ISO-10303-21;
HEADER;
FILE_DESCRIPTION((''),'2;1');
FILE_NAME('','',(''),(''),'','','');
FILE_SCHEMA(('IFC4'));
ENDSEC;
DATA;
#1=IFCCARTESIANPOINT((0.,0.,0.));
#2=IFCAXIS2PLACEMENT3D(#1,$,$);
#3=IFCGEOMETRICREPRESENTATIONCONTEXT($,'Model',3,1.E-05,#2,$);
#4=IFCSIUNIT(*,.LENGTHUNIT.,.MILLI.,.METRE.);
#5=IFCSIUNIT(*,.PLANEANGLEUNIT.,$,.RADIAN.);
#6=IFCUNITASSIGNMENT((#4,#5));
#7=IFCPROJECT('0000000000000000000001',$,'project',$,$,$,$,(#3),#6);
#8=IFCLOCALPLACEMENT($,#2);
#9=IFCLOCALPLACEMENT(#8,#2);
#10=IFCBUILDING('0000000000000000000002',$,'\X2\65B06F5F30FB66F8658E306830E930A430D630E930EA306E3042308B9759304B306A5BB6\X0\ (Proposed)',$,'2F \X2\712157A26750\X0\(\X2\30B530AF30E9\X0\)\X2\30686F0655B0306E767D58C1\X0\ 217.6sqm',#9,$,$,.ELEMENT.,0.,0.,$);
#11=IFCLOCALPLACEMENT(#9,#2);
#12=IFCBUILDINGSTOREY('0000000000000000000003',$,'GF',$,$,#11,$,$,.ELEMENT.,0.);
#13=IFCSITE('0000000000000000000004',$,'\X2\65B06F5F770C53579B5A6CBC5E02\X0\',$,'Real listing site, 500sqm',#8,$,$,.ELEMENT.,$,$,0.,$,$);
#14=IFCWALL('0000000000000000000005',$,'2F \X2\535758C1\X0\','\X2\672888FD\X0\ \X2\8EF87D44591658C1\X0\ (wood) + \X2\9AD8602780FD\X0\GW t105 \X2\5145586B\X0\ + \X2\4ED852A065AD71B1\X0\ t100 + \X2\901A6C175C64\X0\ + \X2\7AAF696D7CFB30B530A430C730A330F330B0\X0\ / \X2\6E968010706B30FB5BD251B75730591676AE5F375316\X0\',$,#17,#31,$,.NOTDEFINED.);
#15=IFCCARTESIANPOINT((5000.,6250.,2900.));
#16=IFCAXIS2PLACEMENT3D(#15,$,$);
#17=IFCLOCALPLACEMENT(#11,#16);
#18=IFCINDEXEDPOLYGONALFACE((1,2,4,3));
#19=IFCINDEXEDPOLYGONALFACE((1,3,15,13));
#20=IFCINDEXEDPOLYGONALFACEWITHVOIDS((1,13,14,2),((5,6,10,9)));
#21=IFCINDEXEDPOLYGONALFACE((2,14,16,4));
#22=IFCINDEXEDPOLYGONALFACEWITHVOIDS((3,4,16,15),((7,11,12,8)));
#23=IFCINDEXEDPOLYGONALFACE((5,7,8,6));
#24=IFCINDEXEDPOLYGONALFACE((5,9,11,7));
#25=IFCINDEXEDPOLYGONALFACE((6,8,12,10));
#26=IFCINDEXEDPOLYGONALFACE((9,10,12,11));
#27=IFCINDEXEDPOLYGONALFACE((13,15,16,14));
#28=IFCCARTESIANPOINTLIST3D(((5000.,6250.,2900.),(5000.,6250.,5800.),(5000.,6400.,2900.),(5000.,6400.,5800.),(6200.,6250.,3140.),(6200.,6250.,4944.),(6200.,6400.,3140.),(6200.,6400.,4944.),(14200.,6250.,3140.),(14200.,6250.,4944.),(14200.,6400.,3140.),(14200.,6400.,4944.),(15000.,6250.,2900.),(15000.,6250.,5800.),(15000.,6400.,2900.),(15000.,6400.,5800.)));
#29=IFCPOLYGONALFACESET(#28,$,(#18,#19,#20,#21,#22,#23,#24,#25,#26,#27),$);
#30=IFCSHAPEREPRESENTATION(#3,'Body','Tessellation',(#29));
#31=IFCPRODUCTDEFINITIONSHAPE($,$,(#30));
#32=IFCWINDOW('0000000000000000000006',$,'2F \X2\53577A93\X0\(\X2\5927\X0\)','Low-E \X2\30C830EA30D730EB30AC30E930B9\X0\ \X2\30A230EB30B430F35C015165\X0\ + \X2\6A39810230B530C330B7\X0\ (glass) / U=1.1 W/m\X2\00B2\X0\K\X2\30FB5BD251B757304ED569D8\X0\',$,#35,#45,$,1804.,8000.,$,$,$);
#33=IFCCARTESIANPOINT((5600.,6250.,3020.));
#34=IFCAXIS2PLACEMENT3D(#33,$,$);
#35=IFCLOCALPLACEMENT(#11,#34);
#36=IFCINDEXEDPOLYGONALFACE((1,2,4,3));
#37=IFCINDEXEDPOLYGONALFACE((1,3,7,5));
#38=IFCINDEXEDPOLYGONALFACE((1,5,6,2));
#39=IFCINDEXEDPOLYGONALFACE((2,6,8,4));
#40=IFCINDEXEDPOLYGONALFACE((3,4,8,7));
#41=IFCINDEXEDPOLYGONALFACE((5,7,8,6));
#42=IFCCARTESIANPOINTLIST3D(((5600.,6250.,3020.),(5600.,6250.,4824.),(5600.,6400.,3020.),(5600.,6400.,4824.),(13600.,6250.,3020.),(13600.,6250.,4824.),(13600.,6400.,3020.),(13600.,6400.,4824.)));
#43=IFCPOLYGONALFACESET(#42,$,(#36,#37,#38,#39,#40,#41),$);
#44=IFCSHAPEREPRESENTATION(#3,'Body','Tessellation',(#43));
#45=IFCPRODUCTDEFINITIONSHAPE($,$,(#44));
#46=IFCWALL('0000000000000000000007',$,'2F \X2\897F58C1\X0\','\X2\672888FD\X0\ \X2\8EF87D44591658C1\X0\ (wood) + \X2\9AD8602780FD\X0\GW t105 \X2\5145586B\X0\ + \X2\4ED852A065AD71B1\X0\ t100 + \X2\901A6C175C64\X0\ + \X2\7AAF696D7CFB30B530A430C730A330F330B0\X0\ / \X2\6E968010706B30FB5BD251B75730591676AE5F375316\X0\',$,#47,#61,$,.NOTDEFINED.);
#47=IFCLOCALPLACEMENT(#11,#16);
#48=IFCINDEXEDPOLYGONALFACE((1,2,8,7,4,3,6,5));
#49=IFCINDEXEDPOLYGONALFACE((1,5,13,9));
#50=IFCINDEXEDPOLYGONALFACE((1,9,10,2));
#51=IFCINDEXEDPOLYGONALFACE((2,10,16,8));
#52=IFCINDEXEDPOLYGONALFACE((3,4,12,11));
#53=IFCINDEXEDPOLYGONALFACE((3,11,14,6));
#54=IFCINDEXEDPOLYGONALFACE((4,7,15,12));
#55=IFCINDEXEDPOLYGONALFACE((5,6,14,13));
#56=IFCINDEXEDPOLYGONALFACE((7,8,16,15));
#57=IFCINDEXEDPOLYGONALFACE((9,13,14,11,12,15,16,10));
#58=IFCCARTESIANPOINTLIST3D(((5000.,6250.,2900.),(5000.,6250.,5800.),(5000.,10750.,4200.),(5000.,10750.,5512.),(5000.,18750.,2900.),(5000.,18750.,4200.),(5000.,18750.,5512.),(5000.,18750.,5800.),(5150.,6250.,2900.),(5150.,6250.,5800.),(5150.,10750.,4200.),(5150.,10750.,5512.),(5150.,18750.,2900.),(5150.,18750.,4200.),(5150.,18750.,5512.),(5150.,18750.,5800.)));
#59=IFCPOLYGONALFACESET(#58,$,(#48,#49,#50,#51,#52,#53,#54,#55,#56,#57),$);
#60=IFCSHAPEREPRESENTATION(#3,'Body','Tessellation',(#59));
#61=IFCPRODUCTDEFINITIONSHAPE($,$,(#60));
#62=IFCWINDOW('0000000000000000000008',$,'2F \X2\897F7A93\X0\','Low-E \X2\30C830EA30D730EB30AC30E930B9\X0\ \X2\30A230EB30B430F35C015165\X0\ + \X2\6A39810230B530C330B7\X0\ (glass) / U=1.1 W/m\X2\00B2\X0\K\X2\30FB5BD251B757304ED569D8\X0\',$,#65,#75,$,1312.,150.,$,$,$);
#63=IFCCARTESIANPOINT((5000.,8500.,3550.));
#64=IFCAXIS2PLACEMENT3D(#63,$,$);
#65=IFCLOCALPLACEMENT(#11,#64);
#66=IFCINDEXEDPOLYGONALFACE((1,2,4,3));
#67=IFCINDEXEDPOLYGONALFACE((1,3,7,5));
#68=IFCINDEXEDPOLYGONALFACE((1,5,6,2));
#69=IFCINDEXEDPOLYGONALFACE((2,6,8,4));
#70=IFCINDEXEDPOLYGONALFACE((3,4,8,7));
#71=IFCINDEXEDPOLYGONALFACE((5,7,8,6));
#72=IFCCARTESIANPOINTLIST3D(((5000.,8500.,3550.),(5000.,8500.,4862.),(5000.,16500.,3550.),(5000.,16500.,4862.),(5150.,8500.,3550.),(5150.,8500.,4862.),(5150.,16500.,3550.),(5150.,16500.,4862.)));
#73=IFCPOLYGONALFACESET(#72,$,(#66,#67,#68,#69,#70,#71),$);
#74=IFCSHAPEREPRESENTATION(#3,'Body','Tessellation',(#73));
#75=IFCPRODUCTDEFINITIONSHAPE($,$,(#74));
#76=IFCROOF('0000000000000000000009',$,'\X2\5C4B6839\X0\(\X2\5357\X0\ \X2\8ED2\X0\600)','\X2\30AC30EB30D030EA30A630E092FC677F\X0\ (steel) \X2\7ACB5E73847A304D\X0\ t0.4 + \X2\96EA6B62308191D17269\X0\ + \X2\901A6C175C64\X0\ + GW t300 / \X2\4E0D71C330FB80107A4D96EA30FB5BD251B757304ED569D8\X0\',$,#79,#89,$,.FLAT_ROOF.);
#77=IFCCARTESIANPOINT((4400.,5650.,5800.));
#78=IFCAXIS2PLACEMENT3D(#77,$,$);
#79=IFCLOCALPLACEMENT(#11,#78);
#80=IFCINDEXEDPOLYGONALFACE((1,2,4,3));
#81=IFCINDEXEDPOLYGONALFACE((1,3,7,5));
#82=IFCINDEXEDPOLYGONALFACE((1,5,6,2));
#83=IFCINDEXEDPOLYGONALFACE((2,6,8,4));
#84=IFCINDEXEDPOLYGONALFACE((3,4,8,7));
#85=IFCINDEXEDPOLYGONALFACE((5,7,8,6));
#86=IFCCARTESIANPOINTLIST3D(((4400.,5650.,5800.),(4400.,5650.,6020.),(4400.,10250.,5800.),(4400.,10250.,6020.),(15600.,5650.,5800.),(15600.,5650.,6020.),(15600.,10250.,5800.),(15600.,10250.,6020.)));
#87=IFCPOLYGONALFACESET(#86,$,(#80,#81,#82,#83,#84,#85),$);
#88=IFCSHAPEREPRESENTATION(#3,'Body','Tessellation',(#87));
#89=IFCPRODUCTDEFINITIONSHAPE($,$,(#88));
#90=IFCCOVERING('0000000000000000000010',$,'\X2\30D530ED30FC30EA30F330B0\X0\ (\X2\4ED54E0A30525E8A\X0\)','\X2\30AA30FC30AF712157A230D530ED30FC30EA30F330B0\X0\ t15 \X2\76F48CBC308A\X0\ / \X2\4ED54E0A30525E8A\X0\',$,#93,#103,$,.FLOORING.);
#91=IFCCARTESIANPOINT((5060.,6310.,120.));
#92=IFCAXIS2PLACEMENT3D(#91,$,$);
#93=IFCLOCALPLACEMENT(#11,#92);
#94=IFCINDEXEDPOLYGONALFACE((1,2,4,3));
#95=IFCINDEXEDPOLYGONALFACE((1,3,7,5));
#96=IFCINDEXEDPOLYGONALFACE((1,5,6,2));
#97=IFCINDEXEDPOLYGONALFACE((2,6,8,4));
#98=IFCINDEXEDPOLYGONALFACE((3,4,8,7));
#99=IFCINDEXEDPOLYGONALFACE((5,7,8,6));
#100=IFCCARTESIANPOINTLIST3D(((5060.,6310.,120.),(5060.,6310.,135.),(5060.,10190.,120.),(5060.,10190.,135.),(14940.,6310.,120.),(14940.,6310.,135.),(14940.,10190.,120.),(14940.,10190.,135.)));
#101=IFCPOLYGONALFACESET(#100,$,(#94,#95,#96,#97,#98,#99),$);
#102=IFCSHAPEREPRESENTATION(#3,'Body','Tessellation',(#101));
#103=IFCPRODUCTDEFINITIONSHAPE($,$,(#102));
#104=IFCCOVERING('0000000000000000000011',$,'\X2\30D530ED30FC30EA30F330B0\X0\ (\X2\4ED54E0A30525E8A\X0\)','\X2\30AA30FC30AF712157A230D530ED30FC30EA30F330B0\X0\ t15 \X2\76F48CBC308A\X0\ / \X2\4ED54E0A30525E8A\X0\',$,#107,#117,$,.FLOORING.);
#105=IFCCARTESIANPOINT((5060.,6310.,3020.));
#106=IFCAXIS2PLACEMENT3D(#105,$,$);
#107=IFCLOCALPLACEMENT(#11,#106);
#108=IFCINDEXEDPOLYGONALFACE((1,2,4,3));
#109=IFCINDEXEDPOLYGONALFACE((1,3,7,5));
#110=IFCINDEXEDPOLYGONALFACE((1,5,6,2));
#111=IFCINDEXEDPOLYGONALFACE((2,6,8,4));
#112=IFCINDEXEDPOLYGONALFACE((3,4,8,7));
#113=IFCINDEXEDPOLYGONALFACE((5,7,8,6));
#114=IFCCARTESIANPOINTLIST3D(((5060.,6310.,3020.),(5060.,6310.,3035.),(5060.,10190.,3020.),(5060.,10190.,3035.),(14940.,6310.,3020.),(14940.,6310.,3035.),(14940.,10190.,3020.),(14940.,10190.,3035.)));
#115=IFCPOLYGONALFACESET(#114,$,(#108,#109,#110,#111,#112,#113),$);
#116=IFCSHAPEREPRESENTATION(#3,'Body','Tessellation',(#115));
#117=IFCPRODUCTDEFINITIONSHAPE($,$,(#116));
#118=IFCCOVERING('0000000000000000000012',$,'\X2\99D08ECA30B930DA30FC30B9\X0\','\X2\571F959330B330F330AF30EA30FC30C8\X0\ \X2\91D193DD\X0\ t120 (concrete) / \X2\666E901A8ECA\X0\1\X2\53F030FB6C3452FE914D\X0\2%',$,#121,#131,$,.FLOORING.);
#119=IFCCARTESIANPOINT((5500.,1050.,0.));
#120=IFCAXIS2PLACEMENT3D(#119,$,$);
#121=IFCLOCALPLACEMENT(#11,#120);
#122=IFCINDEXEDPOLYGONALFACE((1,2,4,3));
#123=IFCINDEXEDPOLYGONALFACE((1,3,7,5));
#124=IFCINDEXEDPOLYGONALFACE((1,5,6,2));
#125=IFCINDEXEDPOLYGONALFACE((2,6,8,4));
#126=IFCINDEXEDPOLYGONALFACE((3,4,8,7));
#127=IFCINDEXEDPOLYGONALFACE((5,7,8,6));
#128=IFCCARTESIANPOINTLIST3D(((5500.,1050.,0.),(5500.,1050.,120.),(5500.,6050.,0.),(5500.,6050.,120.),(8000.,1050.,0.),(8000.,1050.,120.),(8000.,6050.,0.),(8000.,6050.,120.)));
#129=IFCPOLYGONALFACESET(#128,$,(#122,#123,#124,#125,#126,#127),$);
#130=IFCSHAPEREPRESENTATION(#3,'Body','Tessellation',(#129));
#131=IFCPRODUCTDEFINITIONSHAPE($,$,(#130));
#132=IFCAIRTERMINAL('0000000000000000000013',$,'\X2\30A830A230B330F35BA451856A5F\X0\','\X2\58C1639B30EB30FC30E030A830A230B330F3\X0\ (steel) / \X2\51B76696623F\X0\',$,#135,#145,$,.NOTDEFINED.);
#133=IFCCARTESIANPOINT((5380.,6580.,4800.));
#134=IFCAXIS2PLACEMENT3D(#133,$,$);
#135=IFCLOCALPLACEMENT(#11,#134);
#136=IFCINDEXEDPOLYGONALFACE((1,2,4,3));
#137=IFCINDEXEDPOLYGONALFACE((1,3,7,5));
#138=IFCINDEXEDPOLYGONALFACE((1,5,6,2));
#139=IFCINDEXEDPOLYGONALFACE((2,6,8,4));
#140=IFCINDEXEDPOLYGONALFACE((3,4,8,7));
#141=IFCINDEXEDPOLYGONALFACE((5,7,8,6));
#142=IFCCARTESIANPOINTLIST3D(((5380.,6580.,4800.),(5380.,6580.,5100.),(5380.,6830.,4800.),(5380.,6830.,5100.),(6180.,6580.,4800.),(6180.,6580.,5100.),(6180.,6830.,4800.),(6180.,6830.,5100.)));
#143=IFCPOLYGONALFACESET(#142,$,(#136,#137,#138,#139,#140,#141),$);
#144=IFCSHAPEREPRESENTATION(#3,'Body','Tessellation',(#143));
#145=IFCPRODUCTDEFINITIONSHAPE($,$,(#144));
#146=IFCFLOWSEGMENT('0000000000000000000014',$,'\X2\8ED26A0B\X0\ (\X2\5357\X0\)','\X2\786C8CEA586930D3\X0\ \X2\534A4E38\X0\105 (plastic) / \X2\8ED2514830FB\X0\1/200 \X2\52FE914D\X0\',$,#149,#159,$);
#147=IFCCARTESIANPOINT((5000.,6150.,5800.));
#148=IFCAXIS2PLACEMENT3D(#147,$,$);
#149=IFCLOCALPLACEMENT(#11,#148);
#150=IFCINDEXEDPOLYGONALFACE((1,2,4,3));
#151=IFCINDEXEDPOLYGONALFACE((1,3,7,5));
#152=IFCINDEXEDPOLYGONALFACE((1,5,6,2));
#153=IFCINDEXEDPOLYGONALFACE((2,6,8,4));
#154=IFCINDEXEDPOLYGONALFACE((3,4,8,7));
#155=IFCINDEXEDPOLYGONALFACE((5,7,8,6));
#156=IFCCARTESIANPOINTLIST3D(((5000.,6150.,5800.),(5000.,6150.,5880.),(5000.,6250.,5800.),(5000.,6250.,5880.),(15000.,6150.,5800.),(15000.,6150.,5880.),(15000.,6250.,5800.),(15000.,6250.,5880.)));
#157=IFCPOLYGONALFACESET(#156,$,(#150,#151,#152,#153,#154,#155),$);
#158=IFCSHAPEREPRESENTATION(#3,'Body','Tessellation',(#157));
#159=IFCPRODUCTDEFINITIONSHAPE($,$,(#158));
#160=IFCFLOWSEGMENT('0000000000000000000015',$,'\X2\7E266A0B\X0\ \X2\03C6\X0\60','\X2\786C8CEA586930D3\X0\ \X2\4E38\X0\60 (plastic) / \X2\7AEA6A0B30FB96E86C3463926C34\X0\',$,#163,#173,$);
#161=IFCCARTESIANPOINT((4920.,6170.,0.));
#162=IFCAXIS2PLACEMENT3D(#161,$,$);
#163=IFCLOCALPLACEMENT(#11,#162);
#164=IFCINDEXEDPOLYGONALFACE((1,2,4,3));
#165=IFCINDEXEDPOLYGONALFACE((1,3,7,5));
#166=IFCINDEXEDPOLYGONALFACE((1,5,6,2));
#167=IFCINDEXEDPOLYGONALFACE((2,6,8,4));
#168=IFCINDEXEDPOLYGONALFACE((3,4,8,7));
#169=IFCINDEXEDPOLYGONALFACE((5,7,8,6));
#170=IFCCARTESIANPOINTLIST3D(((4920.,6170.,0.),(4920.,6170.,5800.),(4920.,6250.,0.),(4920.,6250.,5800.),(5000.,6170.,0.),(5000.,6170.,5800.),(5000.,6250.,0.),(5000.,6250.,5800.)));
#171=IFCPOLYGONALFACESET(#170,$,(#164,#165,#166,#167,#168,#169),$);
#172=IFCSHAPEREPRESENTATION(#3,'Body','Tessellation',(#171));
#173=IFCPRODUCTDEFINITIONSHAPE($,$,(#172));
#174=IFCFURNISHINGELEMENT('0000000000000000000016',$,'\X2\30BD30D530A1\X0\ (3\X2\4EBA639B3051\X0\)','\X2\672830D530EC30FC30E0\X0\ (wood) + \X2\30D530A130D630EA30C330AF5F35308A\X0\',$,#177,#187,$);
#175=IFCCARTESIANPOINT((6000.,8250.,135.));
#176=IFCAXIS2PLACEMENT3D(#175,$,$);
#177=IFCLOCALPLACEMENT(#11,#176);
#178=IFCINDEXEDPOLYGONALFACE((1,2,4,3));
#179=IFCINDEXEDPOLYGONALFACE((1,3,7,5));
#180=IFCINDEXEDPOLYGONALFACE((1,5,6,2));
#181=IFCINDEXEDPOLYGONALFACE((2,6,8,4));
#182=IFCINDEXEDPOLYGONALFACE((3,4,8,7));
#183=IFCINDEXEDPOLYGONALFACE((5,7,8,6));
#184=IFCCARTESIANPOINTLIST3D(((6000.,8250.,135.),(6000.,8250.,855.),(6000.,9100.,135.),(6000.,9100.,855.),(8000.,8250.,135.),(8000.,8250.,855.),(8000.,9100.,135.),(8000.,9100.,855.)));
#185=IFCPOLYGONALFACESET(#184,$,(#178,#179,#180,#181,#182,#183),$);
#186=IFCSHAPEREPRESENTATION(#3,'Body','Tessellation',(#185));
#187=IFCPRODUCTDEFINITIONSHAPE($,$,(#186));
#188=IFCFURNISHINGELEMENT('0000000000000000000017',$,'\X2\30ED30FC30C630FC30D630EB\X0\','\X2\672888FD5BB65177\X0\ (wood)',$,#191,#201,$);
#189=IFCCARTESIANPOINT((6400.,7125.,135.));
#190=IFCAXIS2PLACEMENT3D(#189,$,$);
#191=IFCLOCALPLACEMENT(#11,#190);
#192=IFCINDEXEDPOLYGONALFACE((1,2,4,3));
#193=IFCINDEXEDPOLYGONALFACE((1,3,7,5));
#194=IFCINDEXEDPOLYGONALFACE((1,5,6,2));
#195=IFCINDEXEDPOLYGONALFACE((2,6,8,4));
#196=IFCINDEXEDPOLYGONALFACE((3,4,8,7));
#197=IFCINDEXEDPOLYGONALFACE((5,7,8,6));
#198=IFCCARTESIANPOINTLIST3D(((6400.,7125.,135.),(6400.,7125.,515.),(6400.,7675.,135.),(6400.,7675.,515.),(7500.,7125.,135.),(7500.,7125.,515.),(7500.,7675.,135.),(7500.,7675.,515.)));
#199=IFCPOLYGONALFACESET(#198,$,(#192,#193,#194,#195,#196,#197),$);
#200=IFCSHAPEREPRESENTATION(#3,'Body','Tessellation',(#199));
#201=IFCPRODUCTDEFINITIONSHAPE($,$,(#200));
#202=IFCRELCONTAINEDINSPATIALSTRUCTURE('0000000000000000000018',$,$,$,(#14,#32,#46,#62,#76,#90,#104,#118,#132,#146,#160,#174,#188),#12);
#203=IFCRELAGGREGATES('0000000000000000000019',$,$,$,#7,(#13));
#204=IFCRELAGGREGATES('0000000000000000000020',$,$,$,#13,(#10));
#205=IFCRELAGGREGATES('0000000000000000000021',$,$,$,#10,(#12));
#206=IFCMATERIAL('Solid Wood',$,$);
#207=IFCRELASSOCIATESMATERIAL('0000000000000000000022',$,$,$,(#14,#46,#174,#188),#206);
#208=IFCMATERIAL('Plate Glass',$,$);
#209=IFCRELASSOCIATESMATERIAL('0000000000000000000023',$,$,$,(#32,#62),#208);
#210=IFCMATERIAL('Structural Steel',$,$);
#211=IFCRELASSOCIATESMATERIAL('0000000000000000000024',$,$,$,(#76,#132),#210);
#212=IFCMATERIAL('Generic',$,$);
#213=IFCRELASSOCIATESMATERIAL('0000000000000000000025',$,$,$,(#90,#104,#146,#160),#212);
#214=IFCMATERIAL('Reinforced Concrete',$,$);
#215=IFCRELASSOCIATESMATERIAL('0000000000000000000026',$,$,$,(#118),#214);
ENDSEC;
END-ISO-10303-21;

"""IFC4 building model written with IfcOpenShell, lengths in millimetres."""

from ifc_helpers import new_model, si_unit, frame, frame_2d, origin, place, context, project, spatial, rectangle, extrude, material, element, fill, save


model = new_model("IFC4")

# Units and contexts
model_context = context("Model", 3, precision=1e-05, world=origin())
ifc_project = project(units=[si_unit("LENGTHUNIT", "METRE", prefix="MILLI"), si_unit("PLANEANGLEUNIT", "RADIAN")], contexts=[model_context])

# Site, building, storey
site_placement = place(None, origin())
site = spatial("IfcSite", under=ifc_project, at=site_placement, Name="新潟県南魚沼市", ObjectType="Real listing site, 500sqm", CompositionType="ELEMENT", RefElevation=0.0)
building_placement = place(site_placement, origin())
building = spatial("IfcBuilding", under=site, at=building_placement, Name="新潟・書斎とライブラリのある静かな家 (Proposed)", ObjectType="2F 無垢材(サクラ)と漆喰の白壁 217.6sqm", CompositionType="ELEMENT", ElevationOfRefHeight=0.0, ElevationOfTerrain=0.0)
storey_placement = place(building_placement, origin())
storey = spatial("IfcBuildingStorey", under=building, at=storey_placement, Name="GF", CompositionType="ELEMENT", Elevation=0.0)

# Shared definitions
ifc_material_1 = material(Name="Solid Wood")

# Shared definitions
ifc_material_2 = material(Name="Reinforced Concrete")

# Shared definitions
ifc_material_3 = material(Name="Plate Glass")

# Walls, openings, windows
wall_1_placement = place(storey_placement, frame((5000.0, 6250.0, 2900.0)))
wall_1 = element("IfcWall", 1, at=wall_1_placement, inside=storey, material=ifc_material_1, Name="2F 南壁", Description="木製 軸組外壁 (wood) + 高性能GW t105 充填 + 付加断熱 t100 + 通気層 + 窯業系サイディング / 準耐火・寒冷地外皮強化", PredefinedType="NOTDEFINED", context=model_context, shape_type="SweptSolid", body=[
    extrude(rectangle(XDim=10000.0, YDim=150.0, at=frame_2d((5000.0, 75.0))), frame((5000.0, 6250.0, 2900.0)), (0.0, 0.0, 1.0), 2900.0),
])
opening_1_placement = place(storey_placement, frame((5600.0, 6250.0, 3020.0)))
opening_1 = element("IfcOpeningElement", 2, at=opening_1_placement, cuts=wall_1, PredefinedType="NOTDEFINED", context=model_context, shape_type="SweptSolid", body=[
    extrude(rectangle(XDim=8000.0, YDim=150.0, at=frame_2d((4000.0, 75.0))), frame((5600.0, 6250.0, 3020.0)), (0.0, 0.0, 1.0), 1804.0),
])
window_1_placement = place(storey_placement, frame((5600.0, 6250.0, 3020.0)))
window_1 = element("IfcWindow", 3, at=window_1_placement, inside=storey, material=ifc_material_3, Name="2F 南窓(大)", Description="Low-E トリプルガラス アルゴン封入 + 樹脂サッシ (glass) / U=1.1 W/m²K・寒冷地仕様", OverallHeight=1804.0, OverallWidth=8000.0, context=model_context, shape_type="SweptSolid", body=[
    extrude(rectangle(XDim=8000.0, YDim=150.0, at=frame_2d((4000.0, 75.0))), frame((5600.0, 6250.0, 3020.0)), (0.0, 0.0, 1.0), 1804.0),
])
fill(opening_1, window_1)
wall_2_placement = place(storey_placement, frame((5000.0, 6250.0, 2900.0)))
wall_2 = element("IfcWall", 4, at=wall_2_placement, inside=storey, material=ifc_material_1, Name="2F 西壁", Description="木製 軸組外壁 (wood) + 高性能GW t105 充填 + 付加断熱 t100 + 通気層 + 窯業系サイディング / 準耐火・寒冷地外皮強化", PredefinedType="NOTDEFINED", context=model_context, shape_type="SweptSolid", body=[
    extrude(rectangle(XDim=150.0, YDim=12500.0, at=frame_2d((75.0, 6250.0))), frame((5000.0, 6250.0, 2900.0)), (0.0, 0.0, 1.0), 2900.0),
])
opening_2_placement = place(storey_placement, frame((5000.0, 8500.0, 3550.0)))
opening_2 = element("IfcOpeningElement", 5, at=opening_2_placement, cuts=wall_2, PredefinedType="NOTDEFINED", context=model_context, shape_type="SweptSolid", body=[
    extrude(rectangle(XDim=150.0, YDim=8000.0, at=frame_2d((75.0, 4000.0))), frame((5000.0, 8500.0, 3550.0)), (0.0, 0.0, 1.0), 1312.0),
])
window_2_placement = place(storey_placement, frame((5000.0, 8500.0, 3550.0)))
window_2 = element("IfcWindow", 6, at=window_2_placement, inside=storey, material=ifc_material_3, Name="2F 西窓", Description="Low-E トリプルガラス アルゴン封入 + 樹脂サッシ (glass) / U=1.1 W/m²K・寒冷地仕様", OverallHeight=1312.0, OverallWidth=150.0, context=model_context, shape_type="SweptSolid", body=[
    extrude(rectangle(XDim=150.0, YDim=8000.0, at=frame_2d((75.0, 4000.0))), frame((5000.0, 8500.0, 3550.0)), (0.0, 0.0, 1.0), 1312.0),
])
fill(opening_2, window_2)

# Roof
ifc_material_4 = material(Name="Structural Steel")
for number, where, name in (
    (7, (4400.0, 5650.0, 5800.0), "屋根(南 軒600)"),
):
    element("IfcRoof", number, at=place(storey_placement, frame(where)), inside=storey, material=ifc_material_4, Name=name, Description="ガルバリウム鋼板 (steel) 立平葺き t0.4 + 雪止め金物 + 通気層 + GW t300 / 不燃・耐積雪・寒冷地仕様", PredefinedType="FLAT_ROOF", context=model_context, shape_type="SweptSolid", body=[
        extrude(rectangle(XDim=11200.0, YDim=4600.0, at=frame_2d((5600.0, 2300.0))), frame((4400.0, 5650.0, 5800.0)), (0.0, 0.0, 1.0), 220.0),
    ])

# Coverings
ifc_material_5 = material(Name="Generic")
covering_1_placement = place(storey_placement, frame((5060.0, 6310.0, 120.0)))
element("IfcCovering", 8, at=covering_1_placement, inside=storey, material=ifc_material_5, Name="フローリング (仕上げ床)", Description="オーク無垢フローリング t15 直貼り / 仕上げ床", PredefinedType="FLOORING", context=model_context, shape_type="SweptSolid", body=[
    extrude(rectangle(XDim=9880.0, YDim=3880.0, at=frame_2d((4940.0, 1940.0))), frame((5060.0, 6310.0, 120.0)), (0.0, 0.0, 1.0), 15.0),
])
covering_2_placement = place(storey_placement, frame((5060.0, 6310.0, 3020.0)))
element("IfcCovering", 9, at=covering_2_placement, inside=storey, material=ifc_material_5, Name="フローリング (仕上げ床)", Description="オーク無垢フローリング t15 直貼り / 仕上げ床", PredefinedType="FLOORING", context=model_context, shape_type="SweptSolid", body=[
    extrude(rectangle(XDim=9880.0, YDim=3880.0, at=frame_2d((4940.0, 1940.0))), frame((5060.0, 6310.0, 3020.0)), (0.0, 0.0, 1.0), 15.0),
])
covering_3_placement = place(storey_placement, frame((5500.0, 1050.0, 0.0)))
element("IfcCovering", 10, at=covering_3_placement, inside=storey, material=ifc_material_2, Name="駐車スペース", Description="土間コンクリート 金鏝 t120 (concrete) / 普通車1台・水勾配2%", PredefinedType="FLOORING", context=model_context, shape_type="SweptSolid", body=[
    extrude(rectangle(XDim=2500.0, YDim=5000.0, at=frame_2d((1250.0, 2500.0))), frame((5500.0, 1050.0, 0.0)), (0.0, 0.0, 1.0), 120.0),
])

# Air terminal
air_terminal_placement = place(storey_placement, frame((5380.0, 6580.0, 4800.0)))
element("IfcAirTerminal", 11, at=air_terminal_placement, inside=storey, material=ifc_material_4, Name="エアコン室内機", Description="壁掛ルームエアコン (steel) / 冷暖房", PredefinedType="NOTDEFINED", context=model_context, shape_type="SweptSolid", body=[
    extrude(rectangle(XDim=800.0, YDim=250.0, at=frame_2d((400.0, 125.0))), frame((5380.0, 6580.0, 4800.0)), (0.0, 0.0, 1.0), 300.0),
])

# Flow segments
flow_segment_1_placement = place(storey_placement, frame((5000.0, 6150.0, 5800.0)))
element("IfcFlowSegment", 12, at=flow_segment_1_placement, inside=storey, material=ifc_material_5, Name="軒樋 (南)", Description="硬質塩ビ 半丸105 (plastic) / 軒先・1/200 勾配", context=model_context, shape_type="SweptSolid", body=[
    extrude(rectangle(XDim=10000.0, YDim=100.0, at=frame_2d((5000.0, 50.0))), frame((5000.0, 6150.0, 5800.0)), (0.0, 0.0, 1.0), 80.0),
])
flow_segment_2_placement = place(storey_placement, frame((4920.0, 6170.0, 0.0)))
element("IfcFlowSegment", 13, at=flow_segment_2_placement, inside=storey, material=ifc_material_5, Name="縦樋 φ60", Description="硬質塩ビ 丸60 (plastic) / 竪樋・雨水排水", context=model_context, shape_type="SweptSolid", body=[
    extrude(rectangle(XDim=80.0, YDim=80.0, at=frame_2d((40.0, 40.0))), frame((4920.0, 6170.0, 0.0)), (0.0, 0.0, 1.0), 5800.0),
])

# Furnishing elements
furnishing_1_placement = place(storey_placement, frame((6000.0, 8250.0, 135.0)))
element("IfcFurnishingElement", 14, at=furnishing_1_placement, inside=storey, material=ifc_material_1, Name="ソファ (3人掛け)", Description="木フレーム (wood) + ファブリック張り", context=model_context, shape_type="SweptSolid", body=[
    extrude(rectangle(XDim=2000.0, YDim=850.0, at=frame_2d((1000.0, 425.0))), frame((6000.0, 8250.0, 135.0)), (0.0, 0.0, 1.0), 720.0),
])
furnishing_2_placement = place(storey_placement, frame((6400.0, 7125.0, 135.0)))
element("IfcFurnishingElement", 15, at=furnishing_2_placement, inside=storey, material=ifc_material_1, Name="ローテーブル", Description="木製家具 (wood)", context=model_context, shape_type="SweptSolid", body=[
    extrude(rectangle(XDim=1100.0, YDim=550.0, at=frame_2d((550.0, 275.0))), frame((6400.0, 7125.0, 135.0)), (0.0, 0.0, 1.0), 380.0),
])

save(model, "model.ifc")
